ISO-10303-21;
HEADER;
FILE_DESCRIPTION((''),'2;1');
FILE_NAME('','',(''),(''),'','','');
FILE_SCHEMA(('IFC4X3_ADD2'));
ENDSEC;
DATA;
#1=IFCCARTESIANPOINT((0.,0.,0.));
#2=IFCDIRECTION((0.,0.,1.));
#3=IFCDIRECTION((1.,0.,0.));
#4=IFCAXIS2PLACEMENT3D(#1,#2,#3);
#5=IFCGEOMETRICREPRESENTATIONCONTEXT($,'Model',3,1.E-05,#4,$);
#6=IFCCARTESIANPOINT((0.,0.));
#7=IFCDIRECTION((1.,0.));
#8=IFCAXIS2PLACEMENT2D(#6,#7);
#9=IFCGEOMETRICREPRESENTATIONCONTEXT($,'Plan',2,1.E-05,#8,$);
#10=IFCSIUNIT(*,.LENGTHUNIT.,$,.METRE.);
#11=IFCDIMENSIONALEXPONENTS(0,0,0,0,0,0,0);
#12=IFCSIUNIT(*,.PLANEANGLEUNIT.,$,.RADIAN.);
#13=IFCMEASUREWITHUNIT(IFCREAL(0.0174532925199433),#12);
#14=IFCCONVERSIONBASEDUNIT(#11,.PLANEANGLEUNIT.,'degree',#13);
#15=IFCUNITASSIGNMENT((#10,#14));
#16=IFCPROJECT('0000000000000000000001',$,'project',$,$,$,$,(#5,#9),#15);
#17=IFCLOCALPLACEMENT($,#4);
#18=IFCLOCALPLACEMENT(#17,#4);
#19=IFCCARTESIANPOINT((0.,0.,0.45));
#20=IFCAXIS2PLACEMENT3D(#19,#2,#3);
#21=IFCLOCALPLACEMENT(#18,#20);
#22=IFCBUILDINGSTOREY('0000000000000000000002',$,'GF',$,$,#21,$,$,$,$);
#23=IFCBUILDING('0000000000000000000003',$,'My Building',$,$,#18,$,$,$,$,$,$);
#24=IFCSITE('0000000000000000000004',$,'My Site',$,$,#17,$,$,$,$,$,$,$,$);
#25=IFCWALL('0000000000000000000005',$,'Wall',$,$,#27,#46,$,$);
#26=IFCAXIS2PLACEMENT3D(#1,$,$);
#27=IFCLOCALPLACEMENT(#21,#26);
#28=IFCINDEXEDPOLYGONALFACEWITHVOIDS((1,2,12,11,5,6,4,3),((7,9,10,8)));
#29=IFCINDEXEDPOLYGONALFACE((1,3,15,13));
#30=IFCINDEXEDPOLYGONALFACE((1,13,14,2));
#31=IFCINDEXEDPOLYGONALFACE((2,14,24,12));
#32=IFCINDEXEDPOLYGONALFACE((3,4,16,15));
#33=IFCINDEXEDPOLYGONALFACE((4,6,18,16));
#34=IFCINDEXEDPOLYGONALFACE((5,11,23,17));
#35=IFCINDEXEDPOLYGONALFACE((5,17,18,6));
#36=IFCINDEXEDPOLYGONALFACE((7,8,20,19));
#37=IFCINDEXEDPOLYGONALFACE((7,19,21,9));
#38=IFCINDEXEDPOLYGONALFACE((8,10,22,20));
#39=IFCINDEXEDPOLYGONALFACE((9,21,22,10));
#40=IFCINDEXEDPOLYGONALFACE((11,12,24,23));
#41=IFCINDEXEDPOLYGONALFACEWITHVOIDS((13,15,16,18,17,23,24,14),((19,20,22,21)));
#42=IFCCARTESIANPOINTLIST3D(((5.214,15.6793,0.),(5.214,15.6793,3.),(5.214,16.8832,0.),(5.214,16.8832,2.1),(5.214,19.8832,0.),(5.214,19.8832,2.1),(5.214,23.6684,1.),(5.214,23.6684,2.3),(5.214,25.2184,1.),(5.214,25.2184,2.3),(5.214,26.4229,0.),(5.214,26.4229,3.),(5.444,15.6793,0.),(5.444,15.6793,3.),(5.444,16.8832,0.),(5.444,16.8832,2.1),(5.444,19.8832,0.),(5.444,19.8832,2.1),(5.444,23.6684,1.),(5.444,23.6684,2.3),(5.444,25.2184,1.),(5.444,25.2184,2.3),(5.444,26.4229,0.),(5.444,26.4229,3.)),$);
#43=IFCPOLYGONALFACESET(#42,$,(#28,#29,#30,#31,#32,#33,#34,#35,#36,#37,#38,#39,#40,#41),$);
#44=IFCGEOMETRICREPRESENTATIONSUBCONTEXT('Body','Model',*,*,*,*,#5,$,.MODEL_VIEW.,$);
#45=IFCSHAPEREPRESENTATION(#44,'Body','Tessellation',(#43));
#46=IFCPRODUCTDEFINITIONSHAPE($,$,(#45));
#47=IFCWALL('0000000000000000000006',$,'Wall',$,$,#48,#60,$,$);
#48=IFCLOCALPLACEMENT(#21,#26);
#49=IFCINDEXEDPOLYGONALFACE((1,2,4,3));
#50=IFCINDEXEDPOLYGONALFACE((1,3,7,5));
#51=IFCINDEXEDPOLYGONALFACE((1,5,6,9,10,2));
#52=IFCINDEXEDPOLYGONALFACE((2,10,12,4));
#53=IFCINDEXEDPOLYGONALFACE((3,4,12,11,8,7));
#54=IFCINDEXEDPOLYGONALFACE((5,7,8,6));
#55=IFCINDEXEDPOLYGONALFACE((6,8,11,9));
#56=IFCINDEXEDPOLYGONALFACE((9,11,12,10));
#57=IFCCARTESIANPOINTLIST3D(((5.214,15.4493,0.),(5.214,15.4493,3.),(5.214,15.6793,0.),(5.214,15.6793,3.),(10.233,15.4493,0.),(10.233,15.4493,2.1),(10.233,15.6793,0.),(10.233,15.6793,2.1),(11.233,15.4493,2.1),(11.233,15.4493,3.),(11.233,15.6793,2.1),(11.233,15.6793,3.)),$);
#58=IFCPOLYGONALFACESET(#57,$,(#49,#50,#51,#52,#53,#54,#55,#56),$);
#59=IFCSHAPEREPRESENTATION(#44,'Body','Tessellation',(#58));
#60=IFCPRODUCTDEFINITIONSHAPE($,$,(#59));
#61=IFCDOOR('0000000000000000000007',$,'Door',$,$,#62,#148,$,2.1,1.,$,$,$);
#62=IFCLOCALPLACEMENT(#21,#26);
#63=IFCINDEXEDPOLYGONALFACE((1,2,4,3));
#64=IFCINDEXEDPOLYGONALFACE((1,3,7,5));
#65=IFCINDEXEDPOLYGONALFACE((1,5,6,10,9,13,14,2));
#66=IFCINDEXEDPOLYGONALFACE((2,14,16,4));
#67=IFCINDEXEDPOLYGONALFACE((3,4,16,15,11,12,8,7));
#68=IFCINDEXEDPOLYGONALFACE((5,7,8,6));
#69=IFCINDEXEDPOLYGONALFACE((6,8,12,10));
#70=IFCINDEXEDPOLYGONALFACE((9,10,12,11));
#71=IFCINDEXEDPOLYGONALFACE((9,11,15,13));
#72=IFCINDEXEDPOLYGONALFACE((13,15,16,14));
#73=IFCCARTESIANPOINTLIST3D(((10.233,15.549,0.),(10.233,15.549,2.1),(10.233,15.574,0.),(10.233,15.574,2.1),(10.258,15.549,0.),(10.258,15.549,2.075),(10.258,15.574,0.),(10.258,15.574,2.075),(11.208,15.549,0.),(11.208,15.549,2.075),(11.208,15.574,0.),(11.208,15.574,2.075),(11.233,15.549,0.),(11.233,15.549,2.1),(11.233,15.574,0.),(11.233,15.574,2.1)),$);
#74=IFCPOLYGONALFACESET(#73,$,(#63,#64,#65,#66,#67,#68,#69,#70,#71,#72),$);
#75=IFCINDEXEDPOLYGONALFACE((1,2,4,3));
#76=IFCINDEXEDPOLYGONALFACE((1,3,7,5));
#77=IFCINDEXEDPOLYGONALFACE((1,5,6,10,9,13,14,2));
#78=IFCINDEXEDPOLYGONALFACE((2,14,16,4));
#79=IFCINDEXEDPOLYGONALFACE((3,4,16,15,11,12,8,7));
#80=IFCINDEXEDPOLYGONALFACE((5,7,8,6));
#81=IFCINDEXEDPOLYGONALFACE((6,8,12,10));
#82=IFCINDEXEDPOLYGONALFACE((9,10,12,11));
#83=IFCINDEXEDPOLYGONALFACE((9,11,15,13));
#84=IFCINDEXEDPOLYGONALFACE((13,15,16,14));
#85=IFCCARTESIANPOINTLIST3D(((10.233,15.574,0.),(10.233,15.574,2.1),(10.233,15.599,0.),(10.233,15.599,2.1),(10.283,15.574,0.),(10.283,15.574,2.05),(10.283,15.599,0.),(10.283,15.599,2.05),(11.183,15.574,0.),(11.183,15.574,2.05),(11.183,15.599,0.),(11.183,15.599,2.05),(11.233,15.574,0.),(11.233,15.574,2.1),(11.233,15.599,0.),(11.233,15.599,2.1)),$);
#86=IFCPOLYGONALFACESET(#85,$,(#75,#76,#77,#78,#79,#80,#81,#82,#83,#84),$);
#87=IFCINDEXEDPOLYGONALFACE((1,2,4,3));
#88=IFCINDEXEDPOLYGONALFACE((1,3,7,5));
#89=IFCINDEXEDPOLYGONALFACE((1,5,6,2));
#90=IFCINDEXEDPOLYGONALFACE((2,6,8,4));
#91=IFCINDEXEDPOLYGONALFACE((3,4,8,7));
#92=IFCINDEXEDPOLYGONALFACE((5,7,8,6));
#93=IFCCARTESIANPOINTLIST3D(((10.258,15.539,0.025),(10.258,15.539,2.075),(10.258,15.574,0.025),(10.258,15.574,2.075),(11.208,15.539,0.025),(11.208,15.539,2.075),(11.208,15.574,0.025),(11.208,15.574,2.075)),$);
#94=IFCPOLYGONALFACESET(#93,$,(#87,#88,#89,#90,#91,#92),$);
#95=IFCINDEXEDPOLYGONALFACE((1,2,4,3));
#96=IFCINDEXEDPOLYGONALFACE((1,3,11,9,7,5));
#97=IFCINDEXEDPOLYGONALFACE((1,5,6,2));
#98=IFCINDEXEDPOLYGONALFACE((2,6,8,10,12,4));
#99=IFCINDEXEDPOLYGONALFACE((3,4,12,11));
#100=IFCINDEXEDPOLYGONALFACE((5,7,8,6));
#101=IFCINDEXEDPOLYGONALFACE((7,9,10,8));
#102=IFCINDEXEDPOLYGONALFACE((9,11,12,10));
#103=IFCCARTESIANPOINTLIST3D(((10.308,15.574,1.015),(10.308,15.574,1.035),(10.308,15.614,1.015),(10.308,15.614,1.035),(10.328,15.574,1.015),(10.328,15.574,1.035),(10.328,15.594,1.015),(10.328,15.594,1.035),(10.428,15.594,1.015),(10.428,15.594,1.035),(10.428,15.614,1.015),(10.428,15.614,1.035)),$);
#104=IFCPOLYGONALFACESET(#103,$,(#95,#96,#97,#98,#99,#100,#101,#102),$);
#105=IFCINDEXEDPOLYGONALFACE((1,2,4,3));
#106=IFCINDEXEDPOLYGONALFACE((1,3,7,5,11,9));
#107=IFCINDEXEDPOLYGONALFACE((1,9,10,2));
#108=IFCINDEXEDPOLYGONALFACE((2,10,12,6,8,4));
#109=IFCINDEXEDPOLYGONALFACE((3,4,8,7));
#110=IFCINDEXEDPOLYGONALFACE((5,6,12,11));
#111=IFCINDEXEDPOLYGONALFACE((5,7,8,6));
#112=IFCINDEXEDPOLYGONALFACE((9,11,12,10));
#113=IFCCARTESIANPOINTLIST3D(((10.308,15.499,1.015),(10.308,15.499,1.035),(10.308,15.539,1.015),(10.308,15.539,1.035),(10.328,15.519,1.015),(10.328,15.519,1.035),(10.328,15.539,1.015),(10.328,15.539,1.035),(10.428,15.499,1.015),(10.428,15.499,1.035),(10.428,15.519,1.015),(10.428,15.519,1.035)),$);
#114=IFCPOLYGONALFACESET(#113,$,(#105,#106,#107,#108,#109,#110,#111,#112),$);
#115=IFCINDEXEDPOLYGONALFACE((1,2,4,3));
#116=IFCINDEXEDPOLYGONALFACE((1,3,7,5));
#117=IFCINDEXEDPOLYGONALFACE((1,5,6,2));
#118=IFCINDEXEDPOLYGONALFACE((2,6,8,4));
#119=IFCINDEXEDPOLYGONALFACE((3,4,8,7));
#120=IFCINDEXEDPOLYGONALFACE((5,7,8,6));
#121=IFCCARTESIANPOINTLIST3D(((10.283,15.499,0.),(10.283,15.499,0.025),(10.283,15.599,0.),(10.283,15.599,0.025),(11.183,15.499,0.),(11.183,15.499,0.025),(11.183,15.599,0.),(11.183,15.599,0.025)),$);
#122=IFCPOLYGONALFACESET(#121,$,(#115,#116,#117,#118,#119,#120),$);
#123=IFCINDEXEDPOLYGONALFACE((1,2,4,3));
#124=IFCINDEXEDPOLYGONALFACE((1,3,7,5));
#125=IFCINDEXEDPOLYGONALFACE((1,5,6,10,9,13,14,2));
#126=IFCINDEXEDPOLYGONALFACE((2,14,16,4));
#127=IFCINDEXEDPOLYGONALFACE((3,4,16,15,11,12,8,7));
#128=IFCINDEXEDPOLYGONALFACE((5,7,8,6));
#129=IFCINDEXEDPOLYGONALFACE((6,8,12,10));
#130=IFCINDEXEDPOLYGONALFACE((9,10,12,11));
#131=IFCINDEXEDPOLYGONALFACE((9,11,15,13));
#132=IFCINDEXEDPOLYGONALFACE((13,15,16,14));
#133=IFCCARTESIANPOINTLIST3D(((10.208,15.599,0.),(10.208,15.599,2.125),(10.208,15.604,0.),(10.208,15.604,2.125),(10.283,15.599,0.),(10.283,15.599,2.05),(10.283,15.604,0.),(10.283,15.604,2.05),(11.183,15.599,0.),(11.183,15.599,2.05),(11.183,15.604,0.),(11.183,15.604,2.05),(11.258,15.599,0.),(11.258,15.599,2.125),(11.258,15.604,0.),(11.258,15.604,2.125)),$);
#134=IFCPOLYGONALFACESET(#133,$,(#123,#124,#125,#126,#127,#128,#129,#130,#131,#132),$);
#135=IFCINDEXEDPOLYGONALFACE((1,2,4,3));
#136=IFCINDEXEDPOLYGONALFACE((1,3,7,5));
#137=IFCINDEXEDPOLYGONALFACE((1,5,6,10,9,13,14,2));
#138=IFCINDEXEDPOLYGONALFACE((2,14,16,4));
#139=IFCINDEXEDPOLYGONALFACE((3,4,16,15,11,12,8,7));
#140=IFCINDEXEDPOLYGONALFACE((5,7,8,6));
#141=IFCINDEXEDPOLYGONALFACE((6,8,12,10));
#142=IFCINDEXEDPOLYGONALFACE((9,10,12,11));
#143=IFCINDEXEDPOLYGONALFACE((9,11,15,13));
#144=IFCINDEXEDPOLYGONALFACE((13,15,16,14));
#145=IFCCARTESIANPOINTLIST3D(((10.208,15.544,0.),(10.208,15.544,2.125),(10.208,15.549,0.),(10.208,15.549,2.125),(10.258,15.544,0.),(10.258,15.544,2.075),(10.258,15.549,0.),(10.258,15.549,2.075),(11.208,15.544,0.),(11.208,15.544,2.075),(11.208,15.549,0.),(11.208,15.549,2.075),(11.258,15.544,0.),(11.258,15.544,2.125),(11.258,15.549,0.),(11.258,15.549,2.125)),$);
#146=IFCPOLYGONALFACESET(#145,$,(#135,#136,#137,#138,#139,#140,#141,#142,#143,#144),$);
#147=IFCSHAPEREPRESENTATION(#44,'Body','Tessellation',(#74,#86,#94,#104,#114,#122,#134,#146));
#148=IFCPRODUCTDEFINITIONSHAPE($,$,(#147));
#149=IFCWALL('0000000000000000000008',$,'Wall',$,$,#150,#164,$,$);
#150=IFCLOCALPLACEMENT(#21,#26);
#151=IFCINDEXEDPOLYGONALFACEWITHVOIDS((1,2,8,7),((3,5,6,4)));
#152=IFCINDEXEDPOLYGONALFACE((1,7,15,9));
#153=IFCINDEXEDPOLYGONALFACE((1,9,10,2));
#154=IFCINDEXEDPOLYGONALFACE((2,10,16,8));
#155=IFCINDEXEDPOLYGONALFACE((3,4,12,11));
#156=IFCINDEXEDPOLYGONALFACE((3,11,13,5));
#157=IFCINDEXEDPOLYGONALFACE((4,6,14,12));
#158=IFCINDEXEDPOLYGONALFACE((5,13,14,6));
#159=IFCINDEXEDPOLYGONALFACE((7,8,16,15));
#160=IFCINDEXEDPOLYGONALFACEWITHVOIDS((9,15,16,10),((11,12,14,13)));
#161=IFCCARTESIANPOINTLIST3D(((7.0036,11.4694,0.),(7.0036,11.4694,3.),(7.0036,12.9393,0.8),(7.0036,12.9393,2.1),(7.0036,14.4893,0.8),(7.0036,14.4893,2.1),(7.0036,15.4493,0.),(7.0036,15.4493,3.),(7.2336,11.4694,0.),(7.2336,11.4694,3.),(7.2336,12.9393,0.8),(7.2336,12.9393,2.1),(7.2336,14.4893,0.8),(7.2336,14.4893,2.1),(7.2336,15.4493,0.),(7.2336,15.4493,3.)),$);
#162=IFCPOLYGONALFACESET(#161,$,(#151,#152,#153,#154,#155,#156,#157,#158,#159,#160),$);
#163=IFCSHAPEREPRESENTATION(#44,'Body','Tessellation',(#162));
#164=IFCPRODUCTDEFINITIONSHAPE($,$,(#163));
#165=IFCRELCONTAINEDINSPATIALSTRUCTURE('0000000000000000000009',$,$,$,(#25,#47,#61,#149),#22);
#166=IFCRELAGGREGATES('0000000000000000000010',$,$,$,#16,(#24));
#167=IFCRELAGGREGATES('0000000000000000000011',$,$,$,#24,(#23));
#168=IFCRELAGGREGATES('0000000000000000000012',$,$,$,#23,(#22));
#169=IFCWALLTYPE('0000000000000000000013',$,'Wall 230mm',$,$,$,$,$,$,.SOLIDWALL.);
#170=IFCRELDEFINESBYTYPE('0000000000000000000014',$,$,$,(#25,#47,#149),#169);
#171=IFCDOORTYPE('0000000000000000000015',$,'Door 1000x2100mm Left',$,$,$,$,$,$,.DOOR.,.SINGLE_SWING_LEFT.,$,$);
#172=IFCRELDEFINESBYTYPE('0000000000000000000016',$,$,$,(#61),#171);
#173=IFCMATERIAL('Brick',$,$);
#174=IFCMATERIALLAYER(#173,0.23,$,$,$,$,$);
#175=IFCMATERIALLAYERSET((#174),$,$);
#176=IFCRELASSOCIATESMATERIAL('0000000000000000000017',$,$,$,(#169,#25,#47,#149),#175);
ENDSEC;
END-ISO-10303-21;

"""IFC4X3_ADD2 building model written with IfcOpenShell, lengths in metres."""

from ifc_helpers import new_model, entity, si_unit, converted_unit, frame, origin_with_axes, origin_2d_with_axis, place, context, subcontext, project, spatial, line, indexed_curve, outline, extrude, shape, source, transform, mapped, material, layer, layer_set, layer_usage, type_object, type_shapes, element, fill, save


model = new_model("IFC4X3_ADD2")

# Units and contexts
model_context = context("Model", 3, precision=1e-05, world=origin_with_axes())
plan_context = context("Plan", 2, precision=1e-05, world=origin_2d_with_axis())
body_context_1 = subcontext(model_context, "Body", "Model", "MODEL_VIEW")
body_context_2 = subcontext(plan_context, "Body", "Plan", "PLAN_VIEW")
ifc_project = project(units=[si_unit("LENGTHUNIT", "METRE"), converted_unit("PLANEANGLEUNIT", "degree", entity("IfcReal", 0.0174532925199433), si_unit("PLANEANGLEUNIT", "RADIAN"), dimensions=[0, 0, 0, 0, 0, 0, 0])], contexts=[model_context, plan_context])

# Site, building, storey
site_placement = place(None, origin_with_axes())
site = spatial("IfcSite", under=ifc_project, at=site_placement, Name="My Site")
building_placement = place(site_placement, origin_with_axes())
building = spatial("IfcBuilding", under=site, at=building_placement, Name="My Building")
storey_placement = place(building_placement, frame((0.0, 0.0, 0.45), z_axis=(0.0, 0.0, 1.0), x_axis=(1.0, 0.0, 0.0)))
storey = spatial("IfcBuildingStorey", under=building, at=storey_placement, Name="GF")

# Wall, openings
ifc_material_1 = material(Name="Brick")
ifc_layer_1 = layer(ifc_material_1, 0.23)
ifc_layer_set_1 = layer_set([ifc_layer_1])
ifc_layer_usage_1 = layer_usage(ifc_layer_set_1, "AXIS2", "POSITIVE", 0.0)
wall_type = type_object("IfcWallType", Name="Wall 230mm", PredefinedType="SOLIDWALL", material=ifc_layer_set_1)
wall_1_placement = place(storey_placement, frame((5.444, 15.6793, 0.0), z_axis=(0.0, 0.0, 1.0), x_axis=(0.0, 1.0, 0.0)))
wall_1 = element("IfcWall", 1, at=wall_1_placement, inside=storey, type_object=wall_type, material=ifc_layer_usage_1, Name="Wall", context=body_context_1, shape_type="SweptSolid", body=[
    extrude(outline(indexed_curve([(0.0, 0.0), (0.0, 0.23), (10.7436, 0.23), (10.7436, 0.0), (0.0, 0.0)], self_intersect=False)), origin_with_axes(), (0.0, 0.0, 1.0), 3.0),
])
shared_shape_1 = source(origin_with_axes(), body_context_1, "Body", "SweptSolid", [
    extrude(outline(indexed_curve([(0.0, 0.0), (3.0, 0.0), (3.0, 2.1), (0.0, 2.1)], segments=[line(1, 2, 3, 4, 1)])), frame((0.0, -0.6, 0.0), z_axis=(0.0, -1.0, 0.0), x_axis=(1.0, 0.0, 0.0)), (0.0, 0.0, -1.0), 1.2),
])
opening_1_placement = place(wall_1_placement, frame((1.2039, 0.0, 0.0), z_axis=(0.0, 0.0, 1.0), x_axis=(1.0, 0.0, 0.0)))
element("IfcOpeningElement", 2, at=opening_1_placement, cuts=wall_1, PredefinedType="OPENING", context=body_context_1, shape_type="MappedRepresentation", body=[
    mapped(shared_shape_1, transform((0.0, 0.0, 0.0), x_axis=(1.0, 0.0, 0.0), y_axis=(0.0, 1.0, 0.0), z_axis=(0.0, 0.0, 1.0), scale=1.0)),
])
shared_shape_2 = source(origin_with_axes(), body_context_1, "Body", "SweptSolid", [
    extrude(outline(indexed_curve([(0.0, 0.0), (1.55, 0.0), (1.55, 1.3), (0.0, 1.3)], segments=[line(1, 2, 3, 4, 1)])), frame((-0.775, -0.6, 0.0), z_axis=(0.0, -1.0, 0.0), x_axis=(1.0, 0.0, 0.0)), (0.0, 0.0, -1.0), 1.2),
])
opening_2_placement = place(wall_1_placement, frame((8.764, 0.0, 1.0), z_axis=(0.0, 0.0, 1.0), x_axis=(1.0, 0.0, 0.0)))
element("IfcOpeningElement", 3, at=opening_2_placement, cuts=wall_1, PredefinedType="OPENING", context=body_context_1, shape_type="MappedRepresentation", body=[
    mapped(shared_shape_2, transform((0.0, 0.0, 0.0), x_axis=(1.0, 0.0, 0.0), y_axis=(0.0, 1.0, 0.0), z_axis=(0.0, 0.0, 1.0), scale=1.0)),
])

# Wall, opening, door
ifc_layer_usage_2 = layer_usage(ifc_layer_set_1, "AXIS2", "POSITIVE", 0.0)
wall_2_placement = place(storey_placement, frame((5.214, 15.4493, 0.0), z_axis=(0.0, 0.0, 1.0), x_axis=(1.0, 0.0, 0.0)))
wall_2 = element("IfcWall", 4, at=wall_2_placement, inside=storey, type_object=wall_type, material=ifc_layer_usage_2, Name="Wall", context=body_context_1, shape_type="SweptSolid", body=[
    extrude(outline(indexed_curve([(0.0, 0.0), (0.0, 0.23), (6.019, 0.23), (6.019, 0.0), (0.0, 0.0)], self_intersect=False)), origin_with_axes(), (0.0, 0.0, 1.0), 3.0),
])
shared_shape_3 = source(origin_with_axes(), body_context_1, "Body", "SweptSolid", [
    extrude(outline(indexed_curve([(0.0, 0.0), (1.0, 0.0), (1.0, 2.1), (0.0, 2.1)], segments=[line(1, 2, 3, 4, 1)])), frame((0.0, -0.6, 0.0), z_axis=(0.0, -1.0, 0.0), x_axis=(1.0, 0.0, 0.0)), (0.0, 0.0, -1.0), 1.2),
])
opening_3_placement = place(wall_2_placement, frame((6.019, 0.1497, 0.0), z_axis=(0.0, 0.0, 1.0), x_axis=(-1.0, 0.0, 0.0)))
opening_3 = element("IfcOpeningElement", 5, at=opening_3_placement, cuts=wall_2, PredefinedType="OPENING", context=body_context_1, shape_type="MappedRepresentation", body=[
    mapped(shared_shape_3, transform((0.0, 0.0, 0.0), x_axis=(1.0, 0.0, 0.0), y_axis=(0.0, 1.0, 0.0), z_axis=(0.0, 0.0, 1.0), scale=1.0)),
])
door_type_1 = type_object("IfcDoorType", Name="Door 1000x2100mm Left", OperationType="SINGLE_SWING_LEFT", PredefinedType="DOOR")
shared_shape_4 = source(origin_with_axes(), body_context_1, "Body", "SweptSolid", [
    extrude(outline(indexed_curve([(0.0, 0.0), (0.0, 2.1), (1.0, 2.1), (1.0, 0.0), (0.975, 0.0), (0.975, 2.075), (0.025, 2.075), (0.025, 0.0)], segments=[line(1, 2, 3, 4, 5, 6, 7, 8, 1)])), frame((0.0, 0.025, 0.0), z_axis=(0.0, -1.0, 0.0), x_axis=(1.0, 0.0, 0.0)), (0.0, 0.0, -1.0), 0.025),
    extrude(outline(indexed_curve([(0.0, 0.0), (0.0, 2.1), (1.0, 2.1), (1.0, 0.0), (0.95, 0.0), (0.95, 2.05), (0.05, 2.05), (0.05, 0.0)], segments=[line(1, 2, 3, 4, 5, 6, 7, 8, 1)])), frame((0.0, 0.0, 0.0), z_axis=(0.0, -1.0, 0.0), x_axis=(1.0, 0.0, 0.0)), (0.0, 0.0, -1.0), 0.025),
    extrude(outline(indexed_curve([(0.0, 0.0), (0.95, 0.0), (0.95, 0.035), (0.0, 0.035)], segments=[line(1, 2, 3, 4, 1)])), frame((0.025, 0.025, 0.025), z_axis=(0.0, 0.0, 1.0), x_axis=(1.0, 0.0, 0.0)), (0.0, 0.0, 1.0), 2.05),
    extrude(outline(indexed_curve([(0.0, 0.0), (0.0, -0.04), (-0.12, -0.04), (-0.12, -0.02), (-0.02, -0.02), (-0.02, 0.0)], segments=[line(1, 2, 3, 4, 5, 6, 1)])), frame((0.925, 0.025, 1.015), z_axis=(0.0, 0.0, 1.0), x_axis=(1.0, 0.0, 0.0)), (0.0, 0.0, 1.0), 0.02),
    extrude(outline(indexed_curve([(0.0, 0.0), (0.0, 0.04), (-0.12, 0.04), (-0.12, 0.02), (-0.02, 0.02), (-0.02, 0.0)], segments=[line(1, 2, 3, 4, 5, 6, 1)])), frame((0.925, 0.06, 1.015), z_axis=(0.0, 0.0, 1.0), x_axis=(1.0, 0.0, 0.0)), (0.0, 0.0, 1.0), 0.02),
    extrude(outline(indexed_curve([(0.0, 0.0), (0.9, 0.0), (0.9, 0.1), (0.0, 0.1)], segments=[line(1, 2, 3, 4, 1)])), frame((0.05, 0.0, 0.0), z_axis=(0.0, 0.0, 1.0), x_axis=(1.0, 0.0, 0.0)), (0.0, 0.0, 1.0), 0.025),
    extrude(outline(indexed_curve([(0.0, 0.0), (0.0, 2.125), (1.05, 2.125), (1.05, 0.0), (0.975, 0.0), (0.975, 2.05), (0.075, 2.05), (0.075, 0.0)], segments=[line(1, 2, 3, 4, 5, 6, 7, 8, 1)])), frame((-0.025, -0.005, 0.0), z_axis=(0.0, -1.0, 0.0), x_axis=(1.0, 0.0, 0.0)), (0.0, 0.0, -1.0), 0.005),
    extrude(outline(indexed_curve([(0.0, 0.0), (0.0, 2.125), (1.05, 2.125), (1.05, 0.0), (1.0, 0.0), (1.0, 2.075), (0.05, 2.075), (0.05, 0.0)], segments=[line(1, 2, 3, 4, 5, 6, 7, 8, 1)])), frame((-0.025, 0.05, 0.0), z_axis=(0.0, -1.0, 0.0), x_axis=(1.0, 0.0, 0.0)), (0.0, 0.0, -1.0), 0.005),
])
shared_shape_5 = source(origin_with_axes(), body_context_2, "Body", "Curve2D", [
    entity("IfcIndexedPolyCurve", entity("IfcCartesianPointList2D", [[0.0, 0.0], [0.0, 0.05], [0.025, 0.05], [0.025, 0.025], [0.05, 0.025], [0.05, 0.0]]), [entity("IfcLineIndex", [1, 2, 3, 4, 5, 6, 1])]),
    entity("IfcIndexedPolyCurve", entity("IfcCartesianPointList2D", [[1.0, 0.0], [1.0, 0.05], [0.975, 0.05], [0.975, 0.025], [0.95, 0.025], [0.95, 0.0]]), [entity("IfcLineIndex", [1, 2, 3, 4, 5, 6, 1])]),
    entity("IfcTrimmedCurve", entity("IfcEllipse", entity("IfcAxis2Placement2D", entity("IfcCartesianPoint", [0.06, 0.05]), entity("IfcDirection", [1.0, 0.0])), 0.915, 0.95), [entity("IfcCartesianPoint", [0.975, 0.05])], [entity("IfcCartesianPoint", [0.06, 1.0])], True, "CARTESIAN"),
    entity("IfcIndexedPolyCurve", entity("IfcCartesianPointList2D", [[0.025, 0.05], [0.06, 0.05], [0.06, 1.0], [0.025, 1.0]]), [entity("IfcLineIndex", [1, 2, 3, 4, 1])]),
])
type_shapes(door_type_1, [shared_shape_4, shared_shape_5])
door_1_placement = place(opening_3_placement, frame((0.0, 0.0, 0.0), z_axis=(0.0, 0.0, 1.0), x_axis=(1.0, 0.0, 0.0)))
door_1 = element("IfcDoor", 6, at=door_1_placement, inside=storey, type_object=door_type_1, Name="Door", OverallHeight=2.1, OverallWidth=1.0, shapes=[
    shape(body_context_1, "Body", "MappedRepresentation", [mapped(shared_shape_4, transform((0.0, 0.0, 0.0), x_axis=(1.0, 0.0, 0.0), y_axis=(0.0, 1.0, 0.0), z_axis=(0.0, 0.0, 1.0), scale=1.0))]),
    shape(body_context_2, "Body", "MappedRepresentation", [mapped(shared_shape_5, transform((0.0, 0.0, 0.0), x_axis=(1.0, 0.0, 0.0), y_axis=(0.0, 1.0, 0.0), z_axis=(0.0, 0.0, 1.0), scale=1.0))]),
])
fill(opening_3, door_1)

# Wall, opening
ifc_layer_usage_3 = layer_usage(ifc_layer_set_1, "AXIS2", "POSITIVE", 0.0)
wall_3_placement = place(storey_placement, frame((7.2336, 11.4694, 0.0), z_axis=(0.0, 0.0, 1.0), x_axis=(0.0, 1.0, 0.0)))
wall_3 = element("IfcWall", 7, at=wall_3_placement, inside=storey, type_object=wall_type, material=ifc_layer_usage_3, Name="Wall", context=body_context_1, shape_type="SweptSolid", body=[
    extrude(outline(indexed_curve([(0.0, 0.0), (0.0, 0.23), (3.98, 0.23), (3.98, 0.0), (0.0, 0.0)], self_intersect=False)), origin_with_axes(), (0.0, 0.0, 1.0), 3.0),
])
opening_4_placement = place(wall_3_placement, frame((2.245, 0.0, 0.8), z_axis=(0.0, 0.0, 1.0), x_axis=(1.0, 0.0, 0.0)))
element("IfcOpeningElement", 8, at=opening_4_placement, cuts=wall_3, PredefinedType="OPENING", context=body_context_1, shape_type="MappedRepresentation", body=[
    mapped(shared_shape_2, transform((0.0, 0.0, 0.0), x_axis=(1.0, 0.0, 0.0), y_axis=(0.0, 1.0, 0.0), z_axis=(0.0, 0.0, 1.0), scale=1.0)),
])

save(model, "model.ifc")
